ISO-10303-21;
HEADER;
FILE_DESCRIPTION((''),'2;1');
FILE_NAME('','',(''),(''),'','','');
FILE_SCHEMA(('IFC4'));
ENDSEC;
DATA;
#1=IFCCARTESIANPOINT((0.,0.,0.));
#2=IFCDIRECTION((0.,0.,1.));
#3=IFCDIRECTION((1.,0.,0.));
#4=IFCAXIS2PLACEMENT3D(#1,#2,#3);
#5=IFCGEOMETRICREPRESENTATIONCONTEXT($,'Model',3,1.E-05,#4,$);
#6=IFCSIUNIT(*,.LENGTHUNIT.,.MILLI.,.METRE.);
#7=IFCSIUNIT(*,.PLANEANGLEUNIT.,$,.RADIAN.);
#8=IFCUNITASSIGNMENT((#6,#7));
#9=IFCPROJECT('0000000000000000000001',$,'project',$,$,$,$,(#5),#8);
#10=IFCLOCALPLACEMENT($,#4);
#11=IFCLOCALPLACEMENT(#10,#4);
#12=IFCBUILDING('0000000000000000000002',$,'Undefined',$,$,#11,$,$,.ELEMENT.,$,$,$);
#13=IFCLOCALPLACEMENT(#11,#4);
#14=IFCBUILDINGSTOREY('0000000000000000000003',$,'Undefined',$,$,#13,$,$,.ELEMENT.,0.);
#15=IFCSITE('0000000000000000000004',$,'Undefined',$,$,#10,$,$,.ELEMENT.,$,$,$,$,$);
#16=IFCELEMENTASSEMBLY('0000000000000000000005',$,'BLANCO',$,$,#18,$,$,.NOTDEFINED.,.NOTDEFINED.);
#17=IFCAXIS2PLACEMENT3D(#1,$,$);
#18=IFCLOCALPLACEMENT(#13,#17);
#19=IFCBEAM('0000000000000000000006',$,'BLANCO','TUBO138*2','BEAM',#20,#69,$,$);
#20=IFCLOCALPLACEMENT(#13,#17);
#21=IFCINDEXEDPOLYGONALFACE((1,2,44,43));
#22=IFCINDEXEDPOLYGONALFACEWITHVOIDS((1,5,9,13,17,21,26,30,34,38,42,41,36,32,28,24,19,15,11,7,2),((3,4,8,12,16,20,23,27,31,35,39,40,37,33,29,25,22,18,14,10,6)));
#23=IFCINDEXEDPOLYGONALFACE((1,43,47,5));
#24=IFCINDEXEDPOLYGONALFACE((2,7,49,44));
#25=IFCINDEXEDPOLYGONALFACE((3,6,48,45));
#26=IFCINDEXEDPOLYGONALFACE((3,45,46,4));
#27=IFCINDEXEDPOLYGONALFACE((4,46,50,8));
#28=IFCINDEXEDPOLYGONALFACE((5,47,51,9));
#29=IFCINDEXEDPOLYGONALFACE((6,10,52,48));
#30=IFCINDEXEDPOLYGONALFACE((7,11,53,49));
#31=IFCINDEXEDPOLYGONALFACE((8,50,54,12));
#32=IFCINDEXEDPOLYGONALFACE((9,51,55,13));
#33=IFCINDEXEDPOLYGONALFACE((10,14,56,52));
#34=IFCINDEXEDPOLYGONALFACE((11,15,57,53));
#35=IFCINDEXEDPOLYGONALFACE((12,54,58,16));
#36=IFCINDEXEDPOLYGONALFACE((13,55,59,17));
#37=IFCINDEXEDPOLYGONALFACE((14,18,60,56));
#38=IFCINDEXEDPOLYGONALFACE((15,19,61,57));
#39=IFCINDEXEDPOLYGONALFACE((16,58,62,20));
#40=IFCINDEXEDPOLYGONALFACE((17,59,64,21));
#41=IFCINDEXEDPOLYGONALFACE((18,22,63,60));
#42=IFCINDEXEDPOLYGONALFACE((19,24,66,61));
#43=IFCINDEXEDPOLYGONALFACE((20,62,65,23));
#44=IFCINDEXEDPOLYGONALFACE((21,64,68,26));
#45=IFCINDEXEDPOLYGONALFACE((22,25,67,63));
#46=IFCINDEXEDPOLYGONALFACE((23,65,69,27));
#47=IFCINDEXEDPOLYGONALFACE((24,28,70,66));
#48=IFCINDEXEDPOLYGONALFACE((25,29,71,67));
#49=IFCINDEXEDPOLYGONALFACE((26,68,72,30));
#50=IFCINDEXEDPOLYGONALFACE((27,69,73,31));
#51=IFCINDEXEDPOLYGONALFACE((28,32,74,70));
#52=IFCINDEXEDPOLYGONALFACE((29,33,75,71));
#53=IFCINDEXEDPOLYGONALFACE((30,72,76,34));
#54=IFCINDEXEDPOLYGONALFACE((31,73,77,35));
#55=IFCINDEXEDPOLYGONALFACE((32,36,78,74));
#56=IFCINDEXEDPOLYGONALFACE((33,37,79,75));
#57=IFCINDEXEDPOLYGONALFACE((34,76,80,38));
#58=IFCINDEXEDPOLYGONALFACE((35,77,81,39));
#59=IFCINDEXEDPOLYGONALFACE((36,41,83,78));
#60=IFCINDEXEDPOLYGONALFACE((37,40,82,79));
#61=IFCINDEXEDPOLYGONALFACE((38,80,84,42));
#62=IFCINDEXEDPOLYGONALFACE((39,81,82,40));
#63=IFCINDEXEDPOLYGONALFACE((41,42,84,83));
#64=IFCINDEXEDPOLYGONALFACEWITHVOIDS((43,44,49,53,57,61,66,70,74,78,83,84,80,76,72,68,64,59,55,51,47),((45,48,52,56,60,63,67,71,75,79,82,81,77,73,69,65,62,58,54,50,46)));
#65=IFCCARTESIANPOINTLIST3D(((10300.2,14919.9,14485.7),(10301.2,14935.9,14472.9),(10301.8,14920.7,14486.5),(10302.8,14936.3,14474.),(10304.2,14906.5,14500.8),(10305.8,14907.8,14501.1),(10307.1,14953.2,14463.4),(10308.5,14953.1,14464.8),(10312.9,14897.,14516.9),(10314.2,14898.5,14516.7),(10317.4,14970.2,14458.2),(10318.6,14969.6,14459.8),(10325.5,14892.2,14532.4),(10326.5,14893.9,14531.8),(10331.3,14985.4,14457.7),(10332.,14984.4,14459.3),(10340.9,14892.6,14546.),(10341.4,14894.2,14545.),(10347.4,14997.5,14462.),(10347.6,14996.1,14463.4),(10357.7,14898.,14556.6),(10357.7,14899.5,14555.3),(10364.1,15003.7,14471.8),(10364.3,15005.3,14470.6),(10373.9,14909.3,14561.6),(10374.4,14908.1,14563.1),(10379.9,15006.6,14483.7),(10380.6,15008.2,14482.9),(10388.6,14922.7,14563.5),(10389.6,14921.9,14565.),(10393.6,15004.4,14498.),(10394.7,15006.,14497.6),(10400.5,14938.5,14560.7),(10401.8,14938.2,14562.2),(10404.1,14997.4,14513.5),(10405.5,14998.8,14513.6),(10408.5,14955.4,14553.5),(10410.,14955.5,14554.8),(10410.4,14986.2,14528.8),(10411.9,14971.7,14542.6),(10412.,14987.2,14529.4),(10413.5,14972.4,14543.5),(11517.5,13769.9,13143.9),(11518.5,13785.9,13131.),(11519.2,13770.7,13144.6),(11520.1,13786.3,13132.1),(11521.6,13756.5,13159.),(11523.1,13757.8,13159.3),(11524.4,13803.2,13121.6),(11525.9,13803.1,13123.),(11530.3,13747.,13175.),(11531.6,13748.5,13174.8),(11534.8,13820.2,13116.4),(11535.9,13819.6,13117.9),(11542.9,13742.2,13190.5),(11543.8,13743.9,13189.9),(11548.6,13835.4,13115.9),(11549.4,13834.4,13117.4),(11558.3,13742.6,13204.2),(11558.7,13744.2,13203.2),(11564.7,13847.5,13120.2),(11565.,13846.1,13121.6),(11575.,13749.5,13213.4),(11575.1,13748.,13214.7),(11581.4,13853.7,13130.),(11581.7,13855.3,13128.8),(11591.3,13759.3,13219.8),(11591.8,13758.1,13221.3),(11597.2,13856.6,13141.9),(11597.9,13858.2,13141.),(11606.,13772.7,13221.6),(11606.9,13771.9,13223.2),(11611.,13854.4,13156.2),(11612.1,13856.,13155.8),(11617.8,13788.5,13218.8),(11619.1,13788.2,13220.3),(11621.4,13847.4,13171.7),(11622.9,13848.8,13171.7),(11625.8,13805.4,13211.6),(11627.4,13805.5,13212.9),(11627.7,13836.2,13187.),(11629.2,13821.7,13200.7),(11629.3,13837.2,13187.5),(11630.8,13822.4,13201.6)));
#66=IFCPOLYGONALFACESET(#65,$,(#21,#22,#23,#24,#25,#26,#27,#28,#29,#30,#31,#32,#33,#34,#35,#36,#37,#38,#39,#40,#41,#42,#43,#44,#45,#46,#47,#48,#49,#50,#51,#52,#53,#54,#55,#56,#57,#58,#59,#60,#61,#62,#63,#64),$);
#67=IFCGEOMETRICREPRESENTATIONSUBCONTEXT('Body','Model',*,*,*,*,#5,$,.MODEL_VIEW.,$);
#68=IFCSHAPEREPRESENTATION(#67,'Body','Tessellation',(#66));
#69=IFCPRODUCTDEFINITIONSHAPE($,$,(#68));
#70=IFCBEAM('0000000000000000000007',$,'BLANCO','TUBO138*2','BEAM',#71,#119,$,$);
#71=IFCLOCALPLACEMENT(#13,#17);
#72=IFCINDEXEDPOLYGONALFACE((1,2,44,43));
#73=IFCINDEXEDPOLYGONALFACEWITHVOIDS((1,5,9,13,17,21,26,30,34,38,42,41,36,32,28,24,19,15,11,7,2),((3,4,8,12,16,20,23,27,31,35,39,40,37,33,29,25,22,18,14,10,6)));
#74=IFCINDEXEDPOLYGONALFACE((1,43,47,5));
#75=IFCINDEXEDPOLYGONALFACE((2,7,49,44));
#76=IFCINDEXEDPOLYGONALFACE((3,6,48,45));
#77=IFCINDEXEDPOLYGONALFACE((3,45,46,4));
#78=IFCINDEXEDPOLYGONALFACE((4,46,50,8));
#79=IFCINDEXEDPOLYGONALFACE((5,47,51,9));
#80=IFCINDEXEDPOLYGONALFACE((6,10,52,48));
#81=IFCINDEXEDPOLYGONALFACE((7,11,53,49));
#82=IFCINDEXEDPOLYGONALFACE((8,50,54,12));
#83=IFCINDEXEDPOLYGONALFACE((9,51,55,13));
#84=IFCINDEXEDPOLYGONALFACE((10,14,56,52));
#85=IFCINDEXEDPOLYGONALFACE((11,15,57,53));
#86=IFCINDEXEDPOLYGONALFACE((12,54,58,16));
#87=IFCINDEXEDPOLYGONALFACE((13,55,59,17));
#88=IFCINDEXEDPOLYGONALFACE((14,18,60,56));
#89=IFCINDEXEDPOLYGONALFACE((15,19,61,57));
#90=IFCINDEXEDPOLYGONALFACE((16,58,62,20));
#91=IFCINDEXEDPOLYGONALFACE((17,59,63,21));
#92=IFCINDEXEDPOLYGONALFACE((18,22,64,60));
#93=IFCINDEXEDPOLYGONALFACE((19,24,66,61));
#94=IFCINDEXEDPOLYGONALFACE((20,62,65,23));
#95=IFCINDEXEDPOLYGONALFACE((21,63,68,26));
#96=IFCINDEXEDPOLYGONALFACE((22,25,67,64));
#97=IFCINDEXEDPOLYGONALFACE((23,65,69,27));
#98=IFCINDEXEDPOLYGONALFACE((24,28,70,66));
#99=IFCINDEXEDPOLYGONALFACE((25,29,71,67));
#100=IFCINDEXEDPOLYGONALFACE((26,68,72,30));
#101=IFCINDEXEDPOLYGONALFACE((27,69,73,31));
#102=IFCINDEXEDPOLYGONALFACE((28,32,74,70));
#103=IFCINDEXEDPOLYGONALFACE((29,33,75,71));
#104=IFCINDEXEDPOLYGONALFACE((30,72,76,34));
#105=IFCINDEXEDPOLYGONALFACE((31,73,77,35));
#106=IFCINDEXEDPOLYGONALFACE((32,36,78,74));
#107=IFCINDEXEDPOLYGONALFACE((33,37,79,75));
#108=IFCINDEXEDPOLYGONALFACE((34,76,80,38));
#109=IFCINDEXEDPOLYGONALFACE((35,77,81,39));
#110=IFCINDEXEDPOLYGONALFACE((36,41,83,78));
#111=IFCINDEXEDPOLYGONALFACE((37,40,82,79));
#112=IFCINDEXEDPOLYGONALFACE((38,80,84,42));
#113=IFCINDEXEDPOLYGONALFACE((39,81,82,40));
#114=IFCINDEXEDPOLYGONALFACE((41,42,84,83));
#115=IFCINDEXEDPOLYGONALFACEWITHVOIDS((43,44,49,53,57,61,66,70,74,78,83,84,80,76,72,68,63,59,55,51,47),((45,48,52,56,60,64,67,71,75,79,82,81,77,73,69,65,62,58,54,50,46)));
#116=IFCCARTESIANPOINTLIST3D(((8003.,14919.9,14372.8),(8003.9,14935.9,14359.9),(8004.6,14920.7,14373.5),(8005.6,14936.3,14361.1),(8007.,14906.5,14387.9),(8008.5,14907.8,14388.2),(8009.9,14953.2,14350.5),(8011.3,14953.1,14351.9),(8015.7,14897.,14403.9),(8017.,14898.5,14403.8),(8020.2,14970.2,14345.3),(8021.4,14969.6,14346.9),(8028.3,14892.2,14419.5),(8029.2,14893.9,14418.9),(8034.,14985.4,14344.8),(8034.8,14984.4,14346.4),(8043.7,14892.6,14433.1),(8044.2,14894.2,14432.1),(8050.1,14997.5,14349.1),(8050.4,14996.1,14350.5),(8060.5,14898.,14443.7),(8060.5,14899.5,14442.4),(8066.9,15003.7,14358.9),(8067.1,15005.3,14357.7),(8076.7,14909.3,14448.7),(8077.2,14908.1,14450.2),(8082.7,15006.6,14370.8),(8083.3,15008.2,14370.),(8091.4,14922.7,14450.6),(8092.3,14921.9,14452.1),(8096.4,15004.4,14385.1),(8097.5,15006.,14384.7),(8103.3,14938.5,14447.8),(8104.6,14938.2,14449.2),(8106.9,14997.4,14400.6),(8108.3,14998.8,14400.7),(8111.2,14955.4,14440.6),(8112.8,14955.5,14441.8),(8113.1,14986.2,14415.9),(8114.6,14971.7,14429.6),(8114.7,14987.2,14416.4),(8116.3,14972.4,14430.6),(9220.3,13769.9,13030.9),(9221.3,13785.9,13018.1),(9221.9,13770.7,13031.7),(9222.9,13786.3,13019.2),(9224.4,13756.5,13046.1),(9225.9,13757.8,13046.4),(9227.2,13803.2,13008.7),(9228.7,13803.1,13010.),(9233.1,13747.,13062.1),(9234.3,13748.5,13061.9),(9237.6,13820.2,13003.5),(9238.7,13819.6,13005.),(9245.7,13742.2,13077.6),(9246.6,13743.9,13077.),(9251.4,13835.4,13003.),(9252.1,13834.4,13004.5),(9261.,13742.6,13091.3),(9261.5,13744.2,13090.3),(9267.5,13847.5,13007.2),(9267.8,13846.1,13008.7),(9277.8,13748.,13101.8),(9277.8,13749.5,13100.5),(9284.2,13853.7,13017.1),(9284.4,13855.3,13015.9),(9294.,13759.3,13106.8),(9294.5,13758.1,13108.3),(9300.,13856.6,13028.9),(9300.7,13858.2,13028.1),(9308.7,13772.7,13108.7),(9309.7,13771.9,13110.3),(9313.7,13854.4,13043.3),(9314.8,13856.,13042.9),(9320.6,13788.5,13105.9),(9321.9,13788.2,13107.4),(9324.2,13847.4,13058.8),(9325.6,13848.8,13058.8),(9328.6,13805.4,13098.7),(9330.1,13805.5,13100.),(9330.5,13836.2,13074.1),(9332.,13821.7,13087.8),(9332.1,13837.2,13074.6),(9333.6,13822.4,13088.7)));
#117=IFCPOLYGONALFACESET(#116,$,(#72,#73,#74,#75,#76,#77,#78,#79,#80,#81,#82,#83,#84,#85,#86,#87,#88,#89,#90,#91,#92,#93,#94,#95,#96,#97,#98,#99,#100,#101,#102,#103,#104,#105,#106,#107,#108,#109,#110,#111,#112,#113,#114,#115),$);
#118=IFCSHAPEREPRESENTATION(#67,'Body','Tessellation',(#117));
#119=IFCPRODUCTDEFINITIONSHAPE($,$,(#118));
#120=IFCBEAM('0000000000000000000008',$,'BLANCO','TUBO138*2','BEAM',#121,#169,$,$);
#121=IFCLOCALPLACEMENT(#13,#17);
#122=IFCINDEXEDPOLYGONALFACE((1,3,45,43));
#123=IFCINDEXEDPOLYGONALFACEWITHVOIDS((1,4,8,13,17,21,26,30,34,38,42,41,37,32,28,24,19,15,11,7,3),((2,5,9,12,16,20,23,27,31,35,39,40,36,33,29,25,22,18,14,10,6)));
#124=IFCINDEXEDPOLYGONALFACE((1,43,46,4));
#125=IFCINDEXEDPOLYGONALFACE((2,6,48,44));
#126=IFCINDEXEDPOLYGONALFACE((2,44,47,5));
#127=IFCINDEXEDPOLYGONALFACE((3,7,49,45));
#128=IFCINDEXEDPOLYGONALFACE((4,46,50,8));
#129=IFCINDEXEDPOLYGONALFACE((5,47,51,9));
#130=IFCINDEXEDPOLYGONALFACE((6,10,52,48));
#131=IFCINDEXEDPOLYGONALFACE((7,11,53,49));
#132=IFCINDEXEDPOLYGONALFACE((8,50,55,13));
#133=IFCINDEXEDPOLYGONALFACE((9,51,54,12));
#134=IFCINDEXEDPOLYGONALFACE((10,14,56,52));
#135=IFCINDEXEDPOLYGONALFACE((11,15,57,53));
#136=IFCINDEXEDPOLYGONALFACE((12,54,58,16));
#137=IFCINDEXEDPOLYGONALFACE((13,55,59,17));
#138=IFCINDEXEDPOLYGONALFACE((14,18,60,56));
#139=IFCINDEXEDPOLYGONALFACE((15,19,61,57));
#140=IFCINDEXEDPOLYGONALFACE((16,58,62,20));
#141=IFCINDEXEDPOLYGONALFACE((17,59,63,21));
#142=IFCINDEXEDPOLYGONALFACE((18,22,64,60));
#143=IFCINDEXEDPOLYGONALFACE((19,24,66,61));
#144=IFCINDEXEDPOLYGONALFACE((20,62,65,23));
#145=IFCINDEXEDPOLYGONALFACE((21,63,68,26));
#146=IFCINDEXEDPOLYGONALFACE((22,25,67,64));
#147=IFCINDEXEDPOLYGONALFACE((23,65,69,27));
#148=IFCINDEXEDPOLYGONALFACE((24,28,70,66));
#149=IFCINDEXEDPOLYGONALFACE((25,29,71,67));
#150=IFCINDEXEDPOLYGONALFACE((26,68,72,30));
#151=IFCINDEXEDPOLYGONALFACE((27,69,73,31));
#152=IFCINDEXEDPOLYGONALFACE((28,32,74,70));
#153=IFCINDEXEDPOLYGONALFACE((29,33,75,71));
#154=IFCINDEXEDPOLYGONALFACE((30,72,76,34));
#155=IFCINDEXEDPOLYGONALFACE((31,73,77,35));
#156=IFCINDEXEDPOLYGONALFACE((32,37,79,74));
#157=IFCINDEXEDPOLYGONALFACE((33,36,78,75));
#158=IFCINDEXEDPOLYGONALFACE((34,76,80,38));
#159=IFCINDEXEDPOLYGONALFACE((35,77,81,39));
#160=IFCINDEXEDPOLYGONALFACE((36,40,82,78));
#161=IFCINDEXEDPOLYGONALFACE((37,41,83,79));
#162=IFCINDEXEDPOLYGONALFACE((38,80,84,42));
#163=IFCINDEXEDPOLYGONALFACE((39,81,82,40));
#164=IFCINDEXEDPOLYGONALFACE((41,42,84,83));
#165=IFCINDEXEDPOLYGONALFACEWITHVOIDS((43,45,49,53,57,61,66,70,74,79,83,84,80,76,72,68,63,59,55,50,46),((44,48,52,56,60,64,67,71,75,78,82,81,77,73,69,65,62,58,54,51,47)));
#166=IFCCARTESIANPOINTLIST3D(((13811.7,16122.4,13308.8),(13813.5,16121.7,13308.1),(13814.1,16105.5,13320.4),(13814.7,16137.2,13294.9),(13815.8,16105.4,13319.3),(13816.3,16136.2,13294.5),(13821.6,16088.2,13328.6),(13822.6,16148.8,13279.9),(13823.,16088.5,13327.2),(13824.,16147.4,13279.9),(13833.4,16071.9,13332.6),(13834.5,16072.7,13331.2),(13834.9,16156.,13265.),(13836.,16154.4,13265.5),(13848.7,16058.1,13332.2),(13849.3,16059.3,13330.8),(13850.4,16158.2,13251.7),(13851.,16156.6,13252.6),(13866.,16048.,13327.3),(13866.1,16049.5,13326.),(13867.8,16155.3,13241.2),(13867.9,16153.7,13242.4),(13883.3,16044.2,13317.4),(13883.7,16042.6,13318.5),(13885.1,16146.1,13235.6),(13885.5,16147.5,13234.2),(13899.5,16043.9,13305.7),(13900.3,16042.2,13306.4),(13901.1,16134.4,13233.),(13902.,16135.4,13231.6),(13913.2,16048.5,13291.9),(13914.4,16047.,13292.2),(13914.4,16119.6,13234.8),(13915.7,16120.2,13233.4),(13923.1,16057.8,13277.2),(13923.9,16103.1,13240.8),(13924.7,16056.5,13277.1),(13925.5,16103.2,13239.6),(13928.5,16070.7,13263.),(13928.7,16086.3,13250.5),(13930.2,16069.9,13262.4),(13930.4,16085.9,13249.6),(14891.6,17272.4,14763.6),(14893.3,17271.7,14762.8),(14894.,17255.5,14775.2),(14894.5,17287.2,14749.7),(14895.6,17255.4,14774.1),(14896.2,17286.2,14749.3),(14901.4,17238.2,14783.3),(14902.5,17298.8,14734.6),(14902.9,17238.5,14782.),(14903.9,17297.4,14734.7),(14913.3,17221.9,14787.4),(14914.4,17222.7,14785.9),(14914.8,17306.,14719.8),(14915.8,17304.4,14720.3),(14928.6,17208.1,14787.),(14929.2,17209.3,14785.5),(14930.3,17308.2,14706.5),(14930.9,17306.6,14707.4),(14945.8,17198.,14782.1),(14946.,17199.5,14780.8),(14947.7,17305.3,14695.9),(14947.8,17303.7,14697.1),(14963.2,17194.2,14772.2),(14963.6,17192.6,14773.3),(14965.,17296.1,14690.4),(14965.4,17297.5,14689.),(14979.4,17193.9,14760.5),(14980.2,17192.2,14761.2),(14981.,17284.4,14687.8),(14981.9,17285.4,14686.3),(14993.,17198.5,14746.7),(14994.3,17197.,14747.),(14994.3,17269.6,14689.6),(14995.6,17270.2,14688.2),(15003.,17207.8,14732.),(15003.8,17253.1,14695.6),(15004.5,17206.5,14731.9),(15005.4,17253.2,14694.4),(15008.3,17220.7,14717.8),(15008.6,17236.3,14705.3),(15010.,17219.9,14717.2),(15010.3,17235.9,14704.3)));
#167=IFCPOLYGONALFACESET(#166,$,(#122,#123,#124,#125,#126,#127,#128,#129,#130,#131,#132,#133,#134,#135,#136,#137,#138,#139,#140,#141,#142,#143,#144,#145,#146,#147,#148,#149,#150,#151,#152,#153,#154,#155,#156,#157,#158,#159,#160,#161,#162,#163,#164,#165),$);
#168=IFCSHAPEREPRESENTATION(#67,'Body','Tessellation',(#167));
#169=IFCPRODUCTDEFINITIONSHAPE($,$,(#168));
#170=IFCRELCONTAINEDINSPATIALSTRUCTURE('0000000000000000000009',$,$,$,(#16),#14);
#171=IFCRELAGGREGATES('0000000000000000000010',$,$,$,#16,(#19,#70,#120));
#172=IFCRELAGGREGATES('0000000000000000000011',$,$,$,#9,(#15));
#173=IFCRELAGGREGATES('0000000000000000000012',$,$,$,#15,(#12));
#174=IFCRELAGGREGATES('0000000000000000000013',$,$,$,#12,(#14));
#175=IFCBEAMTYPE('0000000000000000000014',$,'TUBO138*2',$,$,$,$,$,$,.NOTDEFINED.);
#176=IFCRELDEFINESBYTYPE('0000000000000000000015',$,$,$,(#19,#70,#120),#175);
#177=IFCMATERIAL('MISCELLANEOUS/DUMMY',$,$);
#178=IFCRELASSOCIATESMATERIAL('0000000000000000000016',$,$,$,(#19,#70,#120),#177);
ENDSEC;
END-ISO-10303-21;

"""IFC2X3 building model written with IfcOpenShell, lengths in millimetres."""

from ifc_helpers import new_model, si_unit, frame, origin_with_axes, origin_2d_with_axis, place, context, subcontext, project, spatial, hollow_circle, extrude, material, type_object, element, aggregate, save


model = new_model("IFC2X3")

# Units and contexts
model_context = context("Model", 3, precision=1e-05, world=origin_with_axes())
body_context = subcontext(model_context, "Body", "Model", "MODEL_VIEW")
ifc_project = project(units=[si_unit("LENGTHUNIT", "METRE", prefix="MILLI"), si_unit("PLANEANGLEUNIT", "RADIAN")], contexts=[model_context])

# Site, building, storey
site_placement = place(None, origin_with_axes())
site = spatial("IfcSite", under=ifc_project, at=site_placement, Name="Undefined", CompositionType="ELEMENT")
building_placement = place(site_placement, origin_with_axes())
building = spatial("IfcBuilding", under=site, at=building_placement, Name="Undefined", CompositionType="ELEMENT")
storey_placement = place(building_placement, origin_with_axes())
storey = spatial("IfcBuildingStorey", under=building, at=storey_placement, Name="Undefined", CompositionType="ELEMENT", Elevation=0.0)

# Element assembly, beams
assembly_placement = place(storey_placement, origin_with_axes())
assembly = element("IfcElementAssembly", 1, at=assembly_placement, inside=storey, Name="BLANCO", AssemblyPlace="NOTDEFINED", PredefinedType="NOTDEFINED")
ifc_material = material(Name="MISCELLANEOUS/DUMMY")
beam_type = type_object("IfcBeamType", Name="TUBO138*2", PredefinedType="NOTDEFINED")
beam_1_placement = place(assembly_placement, frame((10356.8, 14950.0, 14511.2), z_axis=(-0.423552, 0.461316, -0.77961), x_axis=(0.567282, -0.535899, -0.625303)))
beam_1 = element("IfcBeam", 2, at=beam_1_placement, type_object=beam_type, material=ifc_material, Name="BLANCO", Description="TUBO138*2", ObjectType="BEAM", context=body_context, shape_type="SweptSolid", body=[
    extrude(hollow_circle(Radius=69.0, WallThickness=2.0, at=origin_2d_with_axis()), frame((2145.9, 0.0, 0.0), z_axis=(-1.0, 0.0, 0.0), x_axis=(0.0, -1.0, 0.0)), (0.0, 0.0, 1.0), 2145.9),
])
beam_2_placement = place(assembly_placement, frame((8059.5, 14950.0, 14398.3), z_axis=(-0.423552, 0.461316, -0.77961), x_axis=(0.567282, -0.535899, -0.625303)))
beam_2 = element("IfcBeam", 3, at=beam_2_placement, type_object=beam_type, material=ifc_material, Name="BLANCO", Description="TUBO138*2", ObjectType="BEAM", context=body_context, shape_type="SweptSolid", body=[
    extrude(hollow_circle(Radius=69.0, WallThickness=2.0, at=origin_2d_with_axis()), frame((2145.9, 0.0, 0.0), z_axis=(-1.0, 0.0, 0.0), x_axis=(0.0, -1.0, 0.0)), (0.0, 0.0, 1.0), 2145.9),
])
beam_3_placement = place(assembly_placement, frame((13871.3, 16100.0, 13282.3), z_axis=(0.497966, 0.461316, -0.734314), x_axis=(0.503224, 0.535899, 0.677922)))
beam_3 = element("IfcBeam", 4, at=beam_3_placement, type_object=beam_type, material=ifc_material, Name="BLANCO", Description="TUBO138*2", ObjectType="BEAM", context=body_context, shape_type="SweptSolid", body=[
    extrude(hollow_circle(Radius=69.0, WallThickness=2.0, at=origin_2d_with_axis()), frame((2145.9, 0.0, 0.0), z_axis=(-1.0, 0.0, 0.0), x_axis=(0.0, -1.0, 0.0)), (0.0, 0.0, 1.0), 2145.9),
])
aggregate(assembly, [beam_1, beam_2, beam_3])

save(model, "model.ifc")
